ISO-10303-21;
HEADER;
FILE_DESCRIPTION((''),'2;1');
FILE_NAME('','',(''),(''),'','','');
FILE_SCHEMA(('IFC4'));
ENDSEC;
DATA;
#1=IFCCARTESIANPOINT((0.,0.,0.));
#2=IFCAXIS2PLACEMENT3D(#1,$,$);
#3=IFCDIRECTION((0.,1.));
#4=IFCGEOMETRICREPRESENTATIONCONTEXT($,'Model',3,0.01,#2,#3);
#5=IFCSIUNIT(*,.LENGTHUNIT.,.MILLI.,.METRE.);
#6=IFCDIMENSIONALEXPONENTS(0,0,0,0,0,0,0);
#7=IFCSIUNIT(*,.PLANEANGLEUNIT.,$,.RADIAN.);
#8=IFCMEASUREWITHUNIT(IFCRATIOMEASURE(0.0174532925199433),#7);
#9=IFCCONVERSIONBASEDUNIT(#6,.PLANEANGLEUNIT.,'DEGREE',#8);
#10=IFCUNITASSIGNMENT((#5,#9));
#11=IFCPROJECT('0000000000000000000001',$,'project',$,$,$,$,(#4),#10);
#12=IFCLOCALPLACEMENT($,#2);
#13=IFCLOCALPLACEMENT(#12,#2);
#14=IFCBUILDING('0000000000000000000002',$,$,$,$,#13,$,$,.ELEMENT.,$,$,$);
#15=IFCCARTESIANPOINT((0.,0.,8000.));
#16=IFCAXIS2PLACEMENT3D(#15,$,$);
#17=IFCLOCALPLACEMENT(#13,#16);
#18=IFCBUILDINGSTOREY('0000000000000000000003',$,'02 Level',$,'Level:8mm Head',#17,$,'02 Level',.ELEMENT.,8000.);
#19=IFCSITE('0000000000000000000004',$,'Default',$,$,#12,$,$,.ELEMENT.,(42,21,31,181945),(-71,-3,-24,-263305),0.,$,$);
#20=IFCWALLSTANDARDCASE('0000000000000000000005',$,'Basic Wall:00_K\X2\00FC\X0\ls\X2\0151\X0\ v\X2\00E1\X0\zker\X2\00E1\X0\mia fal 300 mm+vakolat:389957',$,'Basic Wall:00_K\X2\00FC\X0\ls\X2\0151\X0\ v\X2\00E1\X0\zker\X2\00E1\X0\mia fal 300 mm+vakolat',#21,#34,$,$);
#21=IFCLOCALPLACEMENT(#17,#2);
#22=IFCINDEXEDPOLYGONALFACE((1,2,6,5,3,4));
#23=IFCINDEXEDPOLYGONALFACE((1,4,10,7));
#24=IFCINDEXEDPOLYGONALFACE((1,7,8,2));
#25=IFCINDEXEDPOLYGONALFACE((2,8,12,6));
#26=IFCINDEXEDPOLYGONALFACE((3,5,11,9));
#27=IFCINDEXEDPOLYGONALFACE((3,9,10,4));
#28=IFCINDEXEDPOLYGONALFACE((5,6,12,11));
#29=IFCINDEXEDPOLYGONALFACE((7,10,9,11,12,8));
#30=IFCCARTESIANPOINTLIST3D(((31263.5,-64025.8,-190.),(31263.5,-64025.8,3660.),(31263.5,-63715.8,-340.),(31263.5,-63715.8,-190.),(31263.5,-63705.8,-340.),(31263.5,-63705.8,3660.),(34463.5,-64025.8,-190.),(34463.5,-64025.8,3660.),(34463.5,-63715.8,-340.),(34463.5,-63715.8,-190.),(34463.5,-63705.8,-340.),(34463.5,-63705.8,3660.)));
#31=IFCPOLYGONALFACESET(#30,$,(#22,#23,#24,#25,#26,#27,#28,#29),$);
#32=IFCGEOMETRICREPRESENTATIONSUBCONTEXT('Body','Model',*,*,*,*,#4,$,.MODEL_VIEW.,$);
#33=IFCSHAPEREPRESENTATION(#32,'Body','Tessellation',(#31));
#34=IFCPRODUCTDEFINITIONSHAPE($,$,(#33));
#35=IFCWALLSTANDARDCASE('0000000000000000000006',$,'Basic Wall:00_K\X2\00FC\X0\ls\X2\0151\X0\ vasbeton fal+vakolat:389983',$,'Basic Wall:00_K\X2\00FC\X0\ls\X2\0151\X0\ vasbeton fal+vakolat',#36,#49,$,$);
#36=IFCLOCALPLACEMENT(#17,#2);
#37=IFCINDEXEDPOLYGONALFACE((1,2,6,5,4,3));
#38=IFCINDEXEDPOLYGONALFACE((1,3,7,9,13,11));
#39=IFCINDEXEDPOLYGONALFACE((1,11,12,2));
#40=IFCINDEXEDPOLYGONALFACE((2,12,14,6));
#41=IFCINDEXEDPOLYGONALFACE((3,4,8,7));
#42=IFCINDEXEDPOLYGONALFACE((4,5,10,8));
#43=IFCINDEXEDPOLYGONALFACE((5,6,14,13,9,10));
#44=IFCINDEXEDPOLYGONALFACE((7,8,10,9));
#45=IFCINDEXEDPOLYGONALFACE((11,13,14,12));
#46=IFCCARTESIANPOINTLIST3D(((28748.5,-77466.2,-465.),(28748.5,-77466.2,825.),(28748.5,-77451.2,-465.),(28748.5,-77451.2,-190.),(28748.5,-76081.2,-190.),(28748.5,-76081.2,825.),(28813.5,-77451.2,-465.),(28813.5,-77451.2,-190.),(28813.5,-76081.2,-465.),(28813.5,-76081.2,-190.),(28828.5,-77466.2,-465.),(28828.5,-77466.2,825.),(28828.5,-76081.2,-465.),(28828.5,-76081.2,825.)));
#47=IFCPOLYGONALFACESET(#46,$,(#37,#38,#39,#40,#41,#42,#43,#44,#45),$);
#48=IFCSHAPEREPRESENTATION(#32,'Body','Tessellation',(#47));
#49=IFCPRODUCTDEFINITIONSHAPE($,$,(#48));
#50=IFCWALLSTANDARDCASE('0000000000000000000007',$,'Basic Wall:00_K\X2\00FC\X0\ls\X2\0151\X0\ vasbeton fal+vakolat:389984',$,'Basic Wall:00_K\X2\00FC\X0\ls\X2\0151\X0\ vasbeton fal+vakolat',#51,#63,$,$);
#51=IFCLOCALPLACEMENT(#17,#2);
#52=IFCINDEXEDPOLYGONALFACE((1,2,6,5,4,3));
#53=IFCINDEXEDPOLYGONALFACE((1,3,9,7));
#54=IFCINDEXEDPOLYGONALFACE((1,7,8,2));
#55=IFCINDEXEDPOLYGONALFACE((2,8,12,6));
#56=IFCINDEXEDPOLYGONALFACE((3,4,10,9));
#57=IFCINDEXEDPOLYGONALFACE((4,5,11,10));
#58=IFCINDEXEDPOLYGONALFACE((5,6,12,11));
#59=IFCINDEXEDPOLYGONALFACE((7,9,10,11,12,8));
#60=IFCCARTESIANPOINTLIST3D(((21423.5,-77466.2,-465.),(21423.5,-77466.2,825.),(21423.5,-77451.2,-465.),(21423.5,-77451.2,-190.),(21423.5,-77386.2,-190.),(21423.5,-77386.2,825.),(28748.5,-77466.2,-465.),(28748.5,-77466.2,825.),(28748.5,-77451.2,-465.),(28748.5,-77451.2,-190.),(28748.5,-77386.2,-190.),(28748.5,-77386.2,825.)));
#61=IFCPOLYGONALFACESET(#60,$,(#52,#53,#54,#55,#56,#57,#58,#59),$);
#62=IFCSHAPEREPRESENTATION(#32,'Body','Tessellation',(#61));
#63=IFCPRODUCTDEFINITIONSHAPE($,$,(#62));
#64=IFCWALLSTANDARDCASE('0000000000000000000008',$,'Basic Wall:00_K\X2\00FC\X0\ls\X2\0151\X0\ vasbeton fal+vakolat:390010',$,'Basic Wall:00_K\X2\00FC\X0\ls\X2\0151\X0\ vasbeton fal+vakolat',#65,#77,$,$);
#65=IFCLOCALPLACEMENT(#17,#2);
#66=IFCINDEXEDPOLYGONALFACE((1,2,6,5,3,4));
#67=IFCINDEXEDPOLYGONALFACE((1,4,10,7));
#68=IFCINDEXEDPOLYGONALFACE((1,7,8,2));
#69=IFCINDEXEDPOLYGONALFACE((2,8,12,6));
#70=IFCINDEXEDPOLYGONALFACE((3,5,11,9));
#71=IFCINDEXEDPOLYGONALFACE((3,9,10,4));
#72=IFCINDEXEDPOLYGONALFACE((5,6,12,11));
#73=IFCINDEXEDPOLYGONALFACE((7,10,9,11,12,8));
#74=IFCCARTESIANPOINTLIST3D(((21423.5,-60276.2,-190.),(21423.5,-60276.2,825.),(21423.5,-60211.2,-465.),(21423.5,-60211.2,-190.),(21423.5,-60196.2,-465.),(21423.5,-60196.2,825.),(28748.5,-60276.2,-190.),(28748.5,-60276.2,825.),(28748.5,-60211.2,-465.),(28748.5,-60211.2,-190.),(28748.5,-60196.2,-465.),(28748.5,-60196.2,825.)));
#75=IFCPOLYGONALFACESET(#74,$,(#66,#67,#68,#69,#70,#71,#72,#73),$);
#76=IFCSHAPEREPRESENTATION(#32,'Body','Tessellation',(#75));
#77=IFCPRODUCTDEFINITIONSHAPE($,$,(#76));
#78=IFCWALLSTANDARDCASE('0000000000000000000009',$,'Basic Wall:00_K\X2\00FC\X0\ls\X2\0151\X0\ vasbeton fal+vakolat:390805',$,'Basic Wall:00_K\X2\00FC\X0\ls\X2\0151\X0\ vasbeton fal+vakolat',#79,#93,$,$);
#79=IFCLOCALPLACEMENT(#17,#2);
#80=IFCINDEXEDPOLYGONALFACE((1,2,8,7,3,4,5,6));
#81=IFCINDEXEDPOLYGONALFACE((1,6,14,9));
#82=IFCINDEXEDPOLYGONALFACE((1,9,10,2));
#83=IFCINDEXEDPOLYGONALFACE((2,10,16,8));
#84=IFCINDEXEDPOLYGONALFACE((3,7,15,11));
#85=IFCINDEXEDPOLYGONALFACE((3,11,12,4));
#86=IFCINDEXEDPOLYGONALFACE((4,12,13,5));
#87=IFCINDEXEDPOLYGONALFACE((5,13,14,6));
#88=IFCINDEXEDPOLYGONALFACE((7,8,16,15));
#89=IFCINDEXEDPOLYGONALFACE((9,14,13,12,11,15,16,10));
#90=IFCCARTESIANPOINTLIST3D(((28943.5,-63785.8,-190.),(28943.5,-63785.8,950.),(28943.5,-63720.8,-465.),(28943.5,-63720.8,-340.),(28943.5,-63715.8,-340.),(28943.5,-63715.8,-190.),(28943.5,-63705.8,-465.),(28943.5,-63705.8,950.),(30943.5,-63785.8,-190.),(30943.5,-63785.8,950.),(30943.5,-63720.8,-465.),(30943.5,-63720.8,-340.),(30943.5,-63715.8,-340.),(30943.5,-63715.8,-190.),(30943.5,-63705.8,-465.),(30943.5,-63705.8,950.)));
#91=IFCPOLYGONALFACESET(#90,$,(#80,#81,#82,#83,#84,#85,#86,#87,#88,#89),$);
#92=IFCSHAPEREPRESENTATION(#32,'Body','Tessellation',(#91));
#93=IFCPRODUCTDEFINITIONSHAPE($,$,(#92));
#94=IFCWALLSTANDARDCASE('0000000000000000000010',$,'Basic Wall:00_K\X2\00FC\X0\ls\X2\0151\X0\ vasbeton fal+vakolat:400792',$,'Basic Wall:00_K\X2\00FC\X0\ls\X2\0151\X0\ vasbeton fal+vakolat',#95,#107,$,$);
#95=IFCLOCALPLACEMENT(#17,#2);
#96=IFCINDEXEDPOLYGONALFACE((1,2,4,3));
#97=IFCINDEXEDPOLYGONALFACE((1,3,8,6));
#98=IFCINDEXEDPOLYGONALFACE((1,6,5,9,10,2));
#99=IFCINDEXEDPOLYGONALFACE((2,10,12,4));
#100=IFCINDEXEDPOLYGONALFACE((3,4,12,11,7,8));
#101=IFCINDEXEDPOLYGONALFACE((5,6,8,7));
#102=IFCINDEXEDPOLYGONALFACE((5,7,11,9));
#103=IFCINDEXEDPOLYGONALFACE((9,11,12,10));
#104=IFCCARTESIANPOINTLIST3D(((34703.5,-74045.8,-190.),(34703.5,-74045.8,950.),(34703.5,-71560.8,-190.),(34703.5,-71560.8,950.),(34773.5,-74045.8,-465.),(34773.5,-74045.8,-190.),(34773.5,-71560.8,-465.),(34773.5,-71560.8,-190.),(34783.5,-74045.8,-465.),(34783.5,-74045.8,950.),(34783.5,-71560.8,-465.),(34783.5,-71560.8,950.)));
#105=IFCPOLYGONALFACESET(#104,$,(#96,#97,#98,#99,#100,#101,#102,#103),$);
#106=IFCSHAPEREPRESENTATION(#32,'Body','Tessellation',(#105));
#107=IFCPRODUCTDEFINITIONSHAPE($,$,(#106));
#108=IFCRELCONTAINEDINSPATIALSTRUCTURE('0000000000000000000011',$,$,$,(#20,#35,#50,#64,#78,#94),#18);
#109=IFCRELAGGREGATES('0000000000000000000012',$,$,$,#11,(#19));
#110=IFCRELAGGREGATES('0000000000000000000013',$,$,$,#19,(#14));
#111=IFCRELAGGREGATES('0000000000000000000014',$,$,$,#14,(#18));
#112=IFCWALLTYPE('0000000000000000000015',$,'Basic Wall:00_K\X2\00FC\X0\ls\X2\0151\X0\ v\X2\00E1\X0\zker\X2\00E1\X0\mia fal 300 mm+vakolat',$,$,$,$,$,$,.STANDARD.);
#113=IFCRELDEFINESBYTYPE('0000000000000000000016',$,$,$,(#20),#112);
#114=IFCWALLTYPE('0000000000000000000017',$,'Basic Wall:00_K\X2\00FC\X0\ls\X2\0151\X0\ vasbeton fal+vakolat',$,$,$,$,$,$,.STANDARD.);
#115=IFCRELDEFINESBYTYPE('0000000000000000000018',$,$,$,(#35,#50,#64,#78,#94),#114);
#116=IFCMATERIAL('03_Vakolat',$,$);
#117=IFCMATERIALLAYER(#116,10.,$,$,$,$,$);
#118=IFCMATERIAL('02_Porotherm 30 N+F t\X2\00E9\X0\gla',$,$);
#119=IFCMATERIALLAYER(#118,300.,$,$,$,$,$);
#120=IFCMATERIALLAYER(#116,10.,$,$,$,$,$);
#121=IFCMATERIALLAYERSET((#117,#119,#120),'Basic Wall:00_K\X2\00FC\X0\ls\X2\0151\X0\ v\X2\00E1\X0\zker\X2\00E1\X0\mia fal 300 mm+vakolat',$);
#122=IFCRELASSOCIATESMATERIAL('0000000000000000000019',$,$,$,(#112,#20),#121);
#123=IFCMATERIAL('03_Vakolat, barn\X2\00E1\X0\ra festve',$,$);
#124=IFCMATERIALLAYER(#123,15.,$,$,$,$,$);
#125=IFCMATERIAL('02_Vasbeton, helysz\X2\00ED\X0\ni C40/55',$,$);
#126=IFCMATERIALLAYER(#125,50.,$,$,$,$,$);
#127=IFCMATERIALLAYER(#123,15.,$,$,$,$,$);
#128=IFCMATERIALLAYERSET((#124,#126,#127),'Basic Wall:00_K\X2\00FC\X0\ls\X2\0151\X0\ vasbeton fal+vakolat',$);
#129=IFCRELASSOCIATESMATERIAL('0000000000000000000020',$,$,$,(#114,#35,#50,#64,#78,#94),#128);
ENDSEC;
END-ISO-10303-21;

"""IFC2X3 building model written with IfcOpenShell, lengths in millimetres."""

from ifc_helpers import new_model, entity, si_unit, converted_unit, direction, frame, frame_2d, origin, place, context, subcontext, project, spatial, polyline, rectangle, extrude, clip, bounded_halfspace, material, layer, layer_set, layer_usage, type_object, element, save


model = new_model("IFC2X3")

# Units and contexts
model_context = context("Model", 3, precision=0.01, world=origin(), true_north=direction((0.0, 1.0)))
body_context = subcontext(model_context, "Body", "Model", "MODEL_VIEW")
ifc_project = project(units=[si_unit("LENGTHUNIT", "METRE", prefix="MILLI"), converted_unit("PLANEANGLEUNIT", "DEGREE", entity("IfcRatioMeasure", 0.0174532925199433), si_unit("PLANEANGLEUNIT", "RADIAN"), dimensions=[0, 0, 0, 0, 0, 0, 0])], contexts=[model_context])

# Site, building, storey
site_placement = place(None, origin())
site = spatial("IfcSite", under=ifc_project, at=site_placement, Name="Default", CompositionType="ELEMENT", RefLatitude=(42, 21, 31, 181945), RefLongitude=(-71, -3, -24, -263305), RefElevation=0.0)
building_placement = place(site_placement, origin())
building = spatial("IfcBuilding", under=site, at=building_placement, CompositionType="ELEMENT")
storey_placement = place(building_placement, frame((0.0, 0.0, 8000.0)))
storey = spatial("IfcBuildingStorey", under=building, at=storey_placement, Name="02 Level", ObjectType="Level:8mm Head", LongName="02 Level", CompositionType="ELEMENT", Elevation=8000.0)

# Walls
ifc_material_1 = material(Name="03_Vakolat")
ifc_layer_1 = layer(ifc_material_1, 10.0)
ifc_material_2 = material(Name="02_Porotherm 30 N+F tégla")
ifc_layer_2 = layer(ifc_material_2, 300.0)
ifc_layer_3 = layer(ifc_material_1, 10.0)
ifc_layer_set_1 = layer_set([ifc_layer_1, ifc_layer_2, ifc_layer_3], Name="Basic Wall:00_Külső vázkerámia fal 300 mm+vakolat")
wall_type_1 = type_object("IfcWallType", Name="Basic Wall:00_Külső vázkerámia fal 300 mm+vakolat", PredefinedType="STANDARD", material=ifc_layer_set_1)
ifc_layer_usage_1 = layer_usage(ifc_layer_set_1, "AXIS2", "NEGATIVE", 160.0)
wall_1_placement = place(storey_placement, frame((31263.5, -63865.8, -340.0)))
element("IfcWallStandardCase", 1, at=wall_1_placement, inside=storey, type_object=wall_type_1, material=ifc_layer_usage_1, Name="Basic Wall:00_Külső vázkerámia fal 300 mm+vakolat:389957", ObjectType="Basic Wall:00_Külső vázkerámia fal 300 mm+vakolat", context=body_context, shape_type="Clipping", body=[
    clip(clip(extrude(rectangle(XDim=3200.0, YDim=320.0, at=frame_2d((1600.0, 0.0), x_axis=(-1.0, 0.0))), origin(), (0.0, 0.0, 1.0), 4000.0), bounded_halfspace(frame((0.0, 150.0, 150.0), z_axis=(0.0, 0.0, 1.0), x_axis=(0.0, 1.0, 0.0)), True, frame((0.0, 150.0, 150.0), z_axis=(0.0, 0.0, 1.0), x_axis=(0.0, 1.0, 0.0)), polyline([(0.0, 0.0), (-310.0, 0.0), (-310.0, -3200.0), (0.0, -3200.0), (0.0, 0.0)]))), bounded_halfspace(frame((3200.0, 150.0, 150.0), z_axis=(0.0, 1.0, 0.0), x_axis=(0.0, 0.0, 1.0)), True, frame((3200.0, 150.0, 150.0), z_axis=(0.0, 1.0, 0.0), x_axis=(0.0, 0.0, 1.0)), polyline([(0.0, 0.0), (-150.0, 0.0), (-150.0, -3200.0), (0.0, -3200.0), (0.0, 0.0)]))),
])
ifc_material_3 = material(Name="03_Vakolat, barnára festve")
ifc_layer_4 = layer(ifc_material_3, 15.0)
ifc_material_4 = material(Name="02_Vasbeton, helyszíni C40/55")
ifc_layer_5 = layer(ifc_material_4, 50.0)
ifc_layer_6 = layer(ifc_material_3, 15.0)
ifc_layer_set_2 = layer_set([ifc_layer_4, ifc_layer_5, ifc_layer_6], Name="Basic Wall:00_Külső vasbeton fal+vakolat")
ifc_layer_usage_2 = layer_usage(ifc_layer_set_2, "AXIS2", "NEGATIVE", 40.0)
wall_type_2 = type_object("IfcWallType", Name="Basic Wall:00_Külső vasbeton fal+vakolat", PredefinedType="STANDARD", material=ifc_layer_set_2)
wall_2_placement = place(storey_placement, frame((28788.5, -76081.2, -465.0), z_axis=(0.0, 0.0, 1.0), x_axis=(0.0, -1.0, 0.0)))
element("IfcWallStandardCase", 2, at=wall_2_placement, inside=storey, type_object=wall_type_2, material=ifc_layer_usage_2, Name="Basic Wall:00_Külső vasbeton fal+vakolat:389983", ObjectType="Basic Wall:00_Külső vasbeton fal+vakolat", context=body_context, shape_type="Clipping", body=[
    clip(clip(clip(extrude(rectangle(XDim=1385.0, YDim=80.0, at=frame_2d((692.5, 0.0), x_axis=(-1.0, 0.0))), origin(), (0.0, 0.0, 1.0), 1290.0), bounded_halfspace(frame((1370.0, 25.0, 275.0), z_axis=(0.0, 1.0, 0.0), x_axis=(0.0, 0.0, 1.0)), True, frame((1370.0, 25.0, 275.0), z_axis=(0.0, 1.0, 0.0), x_axis=(0.0, 0.0, 1.0)), polyline([(0.0, 0.0), (-150.0, 0.0), (-275.0, 0.0), (-275.0, -1370.0), (0.0, -1370.0), (0.0, 0.0)]))), bounded_halfspace(frame((1370.0, 25.0, 275.0), z_axis=(1.0, 0.0, 0.0), x_axis=(0.0, 0.0, 1.0)), True, frame((1370.0, 25.0, 275.0), z_axis=(1.0, 0.0, 0.0), x_axis=(0.0, 0.0, 1.0)), polyline([(0.0, 0.0), (0.0, 65.0), (-275.0, 65.0), (-275.0, 0.0), (-150.0, 0.0), (0.0, 0.0)]))), bounded_halfspace(frame((0.0, 25.0, 275.0), z_axis=(0.0, 0.0, 1.0), x_axis=(0.0, -1.0, 0.0)), True, frame((0.0, 25.0, 275.0), z_axis=(0.0, 0.0, 1.0), x_axis=(0.0, -1.0, 0.0)), polyline([(0.0, 0.0), (65.0, 0.0), (65.0, 1305.0), (65.0, 1370.0), (0.0, 1370.0), (0.0, 0.0)]))),
])
ifc_layer_usage_3 = layer_usage(ifc_layer_set_2, "AXIS2", "NEGATIVE", 40.0)
wall_3_placement = place(storey_placement, frame((28748.5, -77426.2, -465.0), z_axis=(0.0, 0.0, 1.0), x_axis=(-1.0, 0.0, 0.0)))
element("IfcWallStandardCase", 3, at=wall_3_placement, inside=storey, type_object=wall_type_2, material=ifc_layer_usage_3, Name="Basic Wall:00_Külső vasbeton fal+vakolat:389984", ObjectType="Basic Wall:00_Külső vasbeton fal+vakolat", context=body_context, shape_type="Clipping", body=[
    clip(clip(extrude(rectangle(XDim=7325.0, YDim=80.0, at=frame_2d((3662.5, 0.0), x_axis=(-1.0, 0.0))), origin(), (0.0, 0.0, 1.0), 1290.0), bounded_halfspace(frame((7325.0, -40.0, 275.0)), True, frame((7325.0, -40.0, 275.0)), polyline([(0.0, 0.0), (0.0, 65.0), (-7325.0, 65.0), (-7325.0, 0.0), (0.0, 0.0)]))), bounded_halfspace(frame((0.0, 25.0, 0.0), z_axis=(0.0, 1.0, 0.0), x_axis=(0.0, 0.0, 1.0)), True, frame((0.0, 25.0, 0.0), z_axis=(0.0, 1.0, 0.0), x_axis=(0.0, 0.0, 1.0)), polyline([(0.0, 0.0), (275.0, 0.0), (275.0, 7325.0), (125.0, 7325.0), (0.0, 7325.0), (0.0, 0.0)]))),
])
ifc_layer_usage_4 = layer_usage(ifc_layer_set_2, "AXIS2", "POSITIVE", -40.0)
wall_4_placement = place(storey_placement, frame((28748.5, -60236.2, -465.0), z_axis=(0.0, 0.0, 1.0), x_axis=(-1.0, 0.0, 0.0)))
element("IfcWallStandardCase", 4, at=wall_4_placement, inside=storey, type_object=wall_type_2, material=ifc_layer_usage_4, Name="Basic Wall:00_Külső vasbeton fal+vakolat:390010", ObjectType="Basic Wall:00_Külső vasbeton fal+vakolat", context=body_context, shape_type="Clipping", body=[
    clip(clip(extrude(rectangle(XDim=7325.0, YDim=80.0, at=frame_2d((3662.5, 0.0), x_axis=(-1.0, 0.0))), origin(), (0.0, 0.0, 1.0), 1290.0), bounded_halfspace(frame((7325.0, -25.0, 275.0)), True, frame((7325.0, -25.0, 275.0)), polyline([(0.0, 0.0), (0.0, 65.0), (-7325.0, 65.0), (-7325.0, 0.0), (0.0, 0.0)]))), bounded_halfspace(frame((0.0, -25.0, 275.0), z_axis=(0.0, -1.0, 0.0), x_axis=(0.0, 0.0, 1.0)), True, frame((0.0, -25.0, 275.0), z_axis=(0.0, -1.0, 0.0), x_axis=(0.0, 0.0, 1.0)), polyline([(0.0, 0.0), (-275.0, 0.0), (-275.0, -7325.0), (0.0, -7325.0), (0.0, 0.0)]))),
])
ifc_layer_usage_5 = layer_usage(ifc_layer_set_2, "AXIS2", "NEGATIVE", 40.0)
wall_5_placement = place(storey_placement, frame((30943.5, -63745.8, -465.0), z_axis=(0.0, 0.0, 1.0), x_axis=(-1.0, 0.0, 0.0)))
element("IfcWallStandardCase", 5, at=wall_5_placement, inside=storey, type_object=wall_type_2, material=ifc_layer_usage_5, Name="Basic Wall:00_Külső vasbeton fal+vakolat:390805", ObjectType="Basic Wall:00_Külső vasbeton fal+vakolat", context=body_context, shape_type="Clipping", body=[
    clip(clip(extrude(rectangle(XDim=2000.0, YDim=80.0, at=frame_2d((1000.0, 0.0), x_axis=(-1.0, 0.0))), origin(), (0.0, 0.0, 1.0), 1415.0), bounded_halfspace(frame((0.0, -30.0, 275.0), z_axis=(0.0, -1.0, 0.0), x_axis=(0.0, 0.0, 1.0)), True, frame((0.0, -30.0, 275.0), z_axis=(0.0, -1.0, 0.0), x_axis=(0.0, 0.0, 1.0)), polyline([(0.0, 0.0), (-150.0, 0.0), (-150.0, -2000.0), (0.0, -2000.0), (0.0, 0.0)]))), bounded_halfspace(frame((2000.0, -25.0, 0.0), z_axis=(0.0, -1.0, 0.0), x_axis=(0.0, 0.0, 1.0)), True, frame((2000.0, -25.0, 0.0), z_axis=(0.0, -1.0, 0.0), x_axis=(0.0, 0.0, 1.0)), polyline([(0.0, 0.0), (125.0, 0.0), (125.0, 2000.0), (0.0, 2000.0), (0.0, 0.0)]))),
])
ifc_layer_usage_6 = layer_usage(ifc_layer_set_2, "AXIS2", "NEGATIVE", 40.0)
wall_6_placement = place(storey_placement, frame((34743.5, -71560.8, -465.0), z_axis=(0.0, 0.0, 1.0), x_axis=(0.0, -1.0, 0.0)))
element("IfcWallStandardCase", 6, at=wall_6_placement, inside=storey, type_object=wall_type_2, material=ifc_layer_usage_6, Name="Basic Wall:00_Külső vasbeton fal+vakolat:400792", ObjectType="Basic Wall:00_Külső vasbeton fal+vakolat", context=body_context, shape_type="Clipping", body=[
    clip(clip(extrude(rectangle(XDim=2485.0, YDim=80.0, at=frame_2d((1242.5, 0.0), x_axis=(-1.0, 0.0))), origin(), (0.0, 0.0, 1.0), 1415.0), bounded_halfspace(frame((2485.0, -40.0, 275.0), z_axis=(0.0, 0.0, 1.0), x_axis=(-1.0, 0.0, 0.0)), True, frame((2485.0, -40.0, 275.0), z_axis=(0.0, 0.0, 1.0), x_axis=(-1.0, 0.0, 0.0)), polyline([(0.0, 0.0), (0.0, -70.0), (2485.0, -70.0), (2485.0, 0.0), (0.0, 0.0)]))), bounded_halfspace(frame((2485.0, 30.0, 275.0), z_axis=(0.0, 1.0, 0.0), x_axis=(0.0, 0.0, 1.0)), True, frame((2485.0, 30.0, 275.0), z_axis=(0.0, 1.0, 0.0), x_axis=(0.0, 0.0, 1.0)), polyline([(0.0, 0.0), (-275.0, 0.0), (-275.0, -2485.0), (-150.0, -2485.0), (0.0, -2485.0), (0.0, 0.0)]))),
])

save(model, "model.ifc")
